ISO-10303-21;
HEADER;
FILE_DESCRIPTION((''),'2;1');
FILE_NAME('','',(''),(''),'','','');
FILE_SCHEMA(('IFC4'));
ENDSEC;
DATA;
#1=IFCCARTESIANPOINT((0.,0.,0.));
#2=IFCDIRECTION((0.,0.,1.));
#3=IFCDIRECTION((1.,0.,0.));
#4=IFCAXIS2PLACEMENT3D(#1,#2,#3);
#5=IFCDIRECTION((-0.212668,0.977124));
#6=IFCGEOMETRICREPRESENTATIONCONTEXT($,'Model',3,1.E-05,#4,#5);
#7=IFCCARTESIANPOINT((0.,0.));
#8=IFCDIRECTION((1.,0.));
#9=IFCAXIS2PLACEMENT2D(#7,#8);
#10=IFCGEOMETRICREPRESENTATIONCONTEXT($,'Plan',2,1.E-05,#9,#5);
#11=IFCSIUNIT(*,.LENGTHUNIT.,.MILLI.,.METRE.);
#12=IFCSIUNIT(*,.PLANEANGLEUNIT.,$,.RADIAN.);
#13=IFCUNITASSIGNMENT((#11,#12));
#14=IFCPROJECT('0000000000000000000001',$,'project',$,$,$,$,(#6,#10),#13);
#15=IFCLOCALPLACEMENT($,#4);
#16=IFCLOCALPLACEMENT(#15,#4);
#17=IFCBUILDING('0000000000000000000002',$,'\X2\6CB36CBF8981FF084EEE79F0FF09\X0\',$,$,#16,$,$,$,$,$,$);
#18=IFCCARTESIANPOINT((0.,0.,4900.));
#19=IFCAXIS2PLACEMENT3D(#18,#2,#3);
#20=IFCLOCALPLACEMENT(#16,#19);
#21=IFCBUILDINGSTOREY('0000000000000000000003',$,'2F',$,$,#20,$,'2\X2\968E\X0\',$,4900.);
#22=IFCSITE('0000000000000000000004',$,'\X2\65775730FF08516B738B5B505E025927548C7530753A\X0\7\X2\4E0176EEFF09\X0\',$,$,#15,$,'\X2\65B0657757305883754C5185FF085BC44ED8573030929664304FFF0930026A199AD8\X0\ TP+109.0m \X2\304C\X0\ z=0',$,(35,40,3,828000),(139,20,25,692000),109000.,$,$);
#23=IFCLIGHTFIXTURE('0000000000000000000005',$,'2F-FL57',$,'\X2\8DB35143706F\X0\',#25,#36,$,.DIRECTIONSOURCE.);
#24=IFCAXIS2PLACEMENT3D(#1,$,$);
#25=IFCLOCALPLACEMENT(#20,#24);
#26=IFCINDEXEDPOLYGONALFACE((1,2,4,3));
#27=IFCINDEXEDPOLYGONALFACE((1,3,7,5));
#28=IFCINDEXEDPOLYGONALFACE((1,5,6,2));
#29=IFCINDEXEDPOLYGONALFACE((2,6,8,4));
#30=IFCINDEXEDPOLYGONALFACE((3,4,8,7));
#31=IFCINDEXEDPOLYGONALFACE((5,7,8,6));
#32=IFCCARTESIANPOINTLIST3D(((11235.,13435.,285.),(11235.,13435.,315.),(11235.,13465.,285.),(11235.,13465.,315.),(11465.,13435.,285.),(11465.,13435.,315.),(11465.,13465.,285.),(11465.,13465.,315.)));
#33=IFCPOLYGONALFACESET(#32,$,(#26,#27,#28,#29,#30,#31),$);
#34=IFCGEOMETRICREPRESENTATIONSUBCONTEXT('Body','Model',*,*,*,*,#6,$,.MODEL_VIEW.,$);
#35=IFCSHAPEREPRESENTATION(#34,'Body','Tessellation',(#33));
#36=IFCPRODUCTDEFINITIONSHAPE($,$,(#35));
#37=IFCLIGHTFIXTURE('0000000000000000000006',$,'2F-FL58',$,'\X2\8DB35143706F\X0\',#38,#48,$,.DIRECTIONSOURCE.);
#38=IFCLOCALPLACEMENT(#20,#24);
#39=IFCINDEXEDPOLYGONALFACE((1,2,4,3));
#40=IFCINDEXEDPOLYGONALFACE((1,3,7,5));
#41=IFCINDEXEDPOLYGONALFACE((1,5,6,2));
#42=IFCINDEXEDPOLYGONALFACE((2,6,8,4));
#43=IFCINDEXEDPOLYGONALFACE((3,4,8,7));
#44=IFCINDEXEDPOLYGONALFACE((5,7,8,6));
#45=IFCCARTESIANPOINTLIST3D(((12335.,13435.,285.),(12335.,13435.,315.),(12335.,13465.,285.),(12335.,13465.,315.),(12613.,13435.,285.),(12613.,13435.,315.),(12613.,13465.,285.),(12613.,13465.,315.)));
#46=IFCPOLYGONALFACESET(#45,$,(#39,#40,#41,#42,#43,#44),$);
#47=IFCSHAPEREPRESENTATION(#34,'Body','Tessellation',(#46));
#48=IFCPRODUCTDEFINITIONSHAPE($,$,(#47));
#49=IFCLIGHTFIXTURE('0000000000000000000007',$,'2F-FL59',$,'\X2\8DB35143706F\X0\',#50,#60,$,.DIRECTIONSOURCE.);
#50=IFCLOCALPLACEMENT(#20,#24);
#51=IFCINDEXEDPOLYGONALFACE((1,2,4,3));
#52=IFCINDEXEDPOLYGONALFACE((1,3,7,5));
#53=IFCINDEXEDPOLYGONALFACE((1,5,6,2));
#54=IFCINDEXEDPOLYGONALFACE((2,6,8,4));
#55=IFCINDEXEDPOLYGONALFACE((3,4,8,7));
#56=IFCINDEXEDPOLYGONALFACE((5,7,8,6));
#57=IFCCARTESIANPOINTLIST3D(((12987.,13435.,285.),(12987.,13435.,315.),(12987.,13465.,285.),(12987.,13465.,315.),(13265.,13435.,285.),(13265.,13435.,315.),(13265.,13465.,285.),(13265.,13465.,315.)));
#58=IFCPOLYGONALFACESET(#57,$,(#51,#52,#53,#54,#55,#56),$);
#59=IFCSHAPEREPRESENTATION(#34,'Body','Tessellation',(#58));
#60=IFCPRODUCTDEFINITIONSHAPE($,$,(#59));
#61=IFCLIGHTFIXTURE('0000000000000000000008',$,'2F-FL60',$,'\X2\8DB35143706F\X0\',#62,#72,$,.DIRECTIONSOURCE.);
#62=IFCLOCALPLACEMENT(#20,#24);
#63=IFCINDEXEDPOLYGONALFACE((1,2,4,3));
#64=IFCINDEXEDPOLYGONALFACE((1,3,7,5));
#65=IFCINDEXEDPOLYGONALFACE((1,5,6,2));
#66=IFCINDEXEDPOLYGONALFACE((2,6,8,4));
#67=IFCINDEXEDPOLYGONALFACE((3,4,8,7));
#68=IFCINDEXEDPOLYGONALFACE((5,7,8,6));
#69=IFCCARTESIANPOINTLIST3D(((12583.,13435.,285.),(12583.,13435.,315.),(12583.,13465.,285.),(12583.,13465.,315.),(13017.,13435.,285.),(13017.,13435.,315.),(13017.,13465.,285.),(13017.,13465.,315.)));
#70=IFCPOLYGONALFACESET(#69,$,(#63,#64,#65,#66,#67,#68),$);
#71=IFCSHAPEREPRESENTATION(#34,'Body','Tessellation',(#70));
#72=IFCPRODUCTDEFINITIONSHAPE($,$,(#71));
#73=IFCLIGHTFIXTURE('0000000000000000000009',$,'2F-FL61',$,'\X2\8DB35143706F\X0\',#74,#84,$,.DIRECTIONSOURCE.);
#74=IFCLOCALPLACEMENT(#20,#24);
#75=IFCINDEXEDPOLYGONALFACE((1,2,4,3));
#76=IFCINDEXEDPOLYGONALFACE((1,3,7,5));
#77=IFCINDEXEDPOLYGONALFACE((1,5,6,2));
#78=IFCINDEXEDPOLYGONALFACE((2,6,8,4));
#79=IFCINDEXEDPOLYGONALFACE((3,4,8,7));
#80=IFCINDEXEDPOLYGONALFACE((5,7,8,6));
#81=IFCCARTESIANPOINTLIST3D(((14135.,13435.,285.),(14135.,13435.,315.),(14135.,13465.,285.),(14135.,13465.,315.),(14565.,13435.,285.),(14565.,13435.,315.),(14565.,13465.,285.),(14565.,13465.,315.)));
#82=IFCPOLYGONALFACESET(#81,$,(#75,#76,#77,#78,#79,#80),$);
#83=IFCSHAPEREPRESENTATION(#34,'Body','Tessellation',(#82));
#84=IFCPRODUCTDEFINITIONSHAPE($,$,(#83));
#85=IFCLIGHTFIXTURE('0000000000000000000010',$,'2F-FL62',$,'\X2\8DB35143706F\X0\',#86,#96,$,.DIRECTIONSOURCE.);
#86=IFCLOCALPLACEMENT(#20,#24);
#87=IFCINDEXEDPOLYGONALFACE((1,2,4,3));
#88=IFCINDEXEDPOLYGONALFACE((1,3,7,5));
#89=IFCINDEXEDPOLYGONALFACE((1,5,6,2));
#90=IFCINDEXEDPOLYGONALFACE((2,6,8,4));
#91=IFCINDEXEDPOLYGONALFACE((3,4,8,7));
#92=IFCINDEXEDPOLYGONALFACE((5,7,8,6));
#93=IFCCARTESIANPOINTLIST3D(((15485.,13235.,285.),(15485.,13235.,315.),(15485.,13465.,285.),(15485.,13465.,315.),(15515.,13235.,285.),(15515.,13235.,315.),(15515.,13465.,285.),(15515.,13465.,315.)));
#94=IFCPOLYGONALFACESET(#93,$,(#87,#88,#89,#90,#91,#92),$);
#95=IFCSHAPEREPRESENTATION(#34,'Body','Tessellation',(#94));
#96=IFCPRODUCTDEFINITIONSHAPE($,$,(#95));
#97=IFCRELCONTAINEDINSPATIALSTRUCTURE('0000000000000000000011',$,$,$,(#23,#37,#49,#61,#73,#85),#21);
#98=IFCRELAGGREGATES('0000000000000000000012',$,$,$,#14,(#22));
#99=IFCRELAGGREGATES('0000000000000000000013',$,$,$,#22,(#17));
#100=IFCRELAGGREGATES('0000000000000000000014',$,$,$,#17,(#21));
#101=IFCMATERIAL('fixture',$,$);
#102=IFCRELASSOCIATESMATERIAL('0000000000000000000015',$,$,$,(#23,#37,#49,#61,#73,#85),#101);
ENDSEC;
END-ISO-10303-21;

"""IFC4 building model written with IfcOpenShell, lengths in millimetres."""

from ifc_helpers import new_model, si_unit, direction, frame, frame_2d, origin_with_axes, origin_2d_with_axis, place, context, subcontext, project, spatial, rectangle, extrude, material, element, save


model = new_model("IFC4")

# Units and contexts
model_context = context("Model", 3, precision=1e-05, world=origin_with_axes(), true_north=direction((-0.212668, 0.977124)))
plan_context = context("Plan", 2, precision=1e-05, world=origin_2d_with_axis(), true_north=direction((-0.212668, 0.977124)))
body_context = subcontext(model_context, "Body", "Model", "MODEL_VIEW")
ifc_project = project(units=[si_unit("LENGTHUNIT", "METRE", prefix="MILLI"), si_unit("PLANEANGLEUNIT", "RADIAN")], contexts=[model_context, plan_context])

# Site, building, storey
site_placement = place(None, origin_with_axes())
site = spatial("IfcSite", under=ifc_project, at=site_placement, Name="敷地（八王子市大和田町7丁目）", LongName="新敷地境界内（寄付地を除く）。標高 TP+109.0m が z=0", RefLatitude=(35, 40, 3, 828000), RefLongitude=(139, 20, 25, 692000), RefElevation=109000.0)
building_placement = place(site_placement, origin_with_axes())
building = spatial("IfcBuilding", under=site, at=building_placement, Name="河沿要（仮称）")
storey_placement = place(building_placement, frame((0.0, 0.0, 4900.0), z_axis=(0.0, 0.0, 1.0), x_axis=(1.0, 0.0, 0.0)))
storey = spatial("IfcBuildingStorey", under=building, at=storey_placement, Name="2F", LongName="2階", Elevation=4900.0)

# Light fixtures
ifc_material = material(Name="fixture")
light_fixture_1_placement = place(storey_placement, origin_with_axes())
element("IfcLightFixture", 1, at=light_fixture_1_placement, inside=storey, material=ifc_material, Name="2F-FL57", ObjectType="足元灯", PredefinedType="DIRECTIONSOURCE", context=body_context, shape_type="SweptSolid", body=[
    extrude(rectangle(XDim=230.0, YDim=30.0, at=frame_2d((11350.0, 13450.0))), frame((0.0, 0.0, 285.0)), (0.0, 0.0, 1.0), 30.0),
])
light_fixture_2_placement = place(storey_placement, origin_with_axes())
element("IfcLightFixture", 2, at=light_fixture_2_placement, inside=storey, material=ifc_material, Name="2F-FL58", ObjectType="足元灯", PredefinedType="DIRECTIONSOURCE", context=body_context, shape_type="SweptSolid", body=[
    extrude(rectangle(XDim=278.0, YDim=30.0, at=frame_2d((12474.0, 13450.0))), frame((0.0, 0.0, 285.0)), (0.0, 0.0, 1.0), 30.0),
])
light_fixture_3_placement = place(storey_placement, origin_with_axes())
element("IfcLightFixture", 3, at=light_fixture_3_placement, inside=storey, material=ifc_material, Name="2F-FL59", ObjectType="足元灯", PredefinedType="DIRECTIONSOURCE", context=body_context, shape_type="SweptSolid", body=[
    extrude(rectangle(XDim=278.0, YDim=30.0, at=frame_2d((13126.0, 13450.0))), frame((0.0, 0.0, 285.0)), (0.0, 0.0, 1.0), 30.0),
])
light_fixture_4_placement = place(storey_placement, origin_with_axes())
element("IfcLightFixture", 4, at=light_fixture_4_placement, inside=storey, material=ifc_material, Name="2F-FL60", ObjectType="足元灯", PredefinedType="DIRECTIONSOURCE", context=body_context, shape_type="SweptSolid", body=[
    extrude(rectangle(XDim=434.0, YDim=30.0, at=frame_2d((12800.0, 13450.0))), frame((0.0, 0.0, 285.0)), (0.0, 0.0, 1.0), 30.0),
])
light_fixture_5_placement = place(storey_placement, origin_with_axes())
element("IfcLightFixture", 5, at=light_fixture_5_placement, inside=storey, material=ifc_material, Name="2F-FL61", ObjectType="足元灯", PredefinedType="DIRECTIONSOURCE", context=body_context, shape_type="SweptSolid", body=[
    extrude(rectangle(XDim=430.0, YDim=30.0, at=frame_2d((14350.0, 13450.0))), frame((0.0, 0.0, 285.0)), (0.0, 0.0, 1.0), 30.0),
])
light_fixture_6_placement = place(storey_placement, origin_with_axes())
element("IfcLightFixture", 6, at=light_fixture_6_placement, inside=storey, material=ifc_material, Name="2F-FL62", ObjectType="足元灯", PredefinedType="DIRECTIONSOURCE", context=body_context, shape_type="SweptSolid", body=[
    extrude(rectangle(XDim=30.0, YDim=230.0, at=frame_2d((15500.0, 13350.0))), frame((0.0, 0.0, 285.0)), (0.0, 0.0, 1.0), 30.0),
])

save(model, "model.ifc")
